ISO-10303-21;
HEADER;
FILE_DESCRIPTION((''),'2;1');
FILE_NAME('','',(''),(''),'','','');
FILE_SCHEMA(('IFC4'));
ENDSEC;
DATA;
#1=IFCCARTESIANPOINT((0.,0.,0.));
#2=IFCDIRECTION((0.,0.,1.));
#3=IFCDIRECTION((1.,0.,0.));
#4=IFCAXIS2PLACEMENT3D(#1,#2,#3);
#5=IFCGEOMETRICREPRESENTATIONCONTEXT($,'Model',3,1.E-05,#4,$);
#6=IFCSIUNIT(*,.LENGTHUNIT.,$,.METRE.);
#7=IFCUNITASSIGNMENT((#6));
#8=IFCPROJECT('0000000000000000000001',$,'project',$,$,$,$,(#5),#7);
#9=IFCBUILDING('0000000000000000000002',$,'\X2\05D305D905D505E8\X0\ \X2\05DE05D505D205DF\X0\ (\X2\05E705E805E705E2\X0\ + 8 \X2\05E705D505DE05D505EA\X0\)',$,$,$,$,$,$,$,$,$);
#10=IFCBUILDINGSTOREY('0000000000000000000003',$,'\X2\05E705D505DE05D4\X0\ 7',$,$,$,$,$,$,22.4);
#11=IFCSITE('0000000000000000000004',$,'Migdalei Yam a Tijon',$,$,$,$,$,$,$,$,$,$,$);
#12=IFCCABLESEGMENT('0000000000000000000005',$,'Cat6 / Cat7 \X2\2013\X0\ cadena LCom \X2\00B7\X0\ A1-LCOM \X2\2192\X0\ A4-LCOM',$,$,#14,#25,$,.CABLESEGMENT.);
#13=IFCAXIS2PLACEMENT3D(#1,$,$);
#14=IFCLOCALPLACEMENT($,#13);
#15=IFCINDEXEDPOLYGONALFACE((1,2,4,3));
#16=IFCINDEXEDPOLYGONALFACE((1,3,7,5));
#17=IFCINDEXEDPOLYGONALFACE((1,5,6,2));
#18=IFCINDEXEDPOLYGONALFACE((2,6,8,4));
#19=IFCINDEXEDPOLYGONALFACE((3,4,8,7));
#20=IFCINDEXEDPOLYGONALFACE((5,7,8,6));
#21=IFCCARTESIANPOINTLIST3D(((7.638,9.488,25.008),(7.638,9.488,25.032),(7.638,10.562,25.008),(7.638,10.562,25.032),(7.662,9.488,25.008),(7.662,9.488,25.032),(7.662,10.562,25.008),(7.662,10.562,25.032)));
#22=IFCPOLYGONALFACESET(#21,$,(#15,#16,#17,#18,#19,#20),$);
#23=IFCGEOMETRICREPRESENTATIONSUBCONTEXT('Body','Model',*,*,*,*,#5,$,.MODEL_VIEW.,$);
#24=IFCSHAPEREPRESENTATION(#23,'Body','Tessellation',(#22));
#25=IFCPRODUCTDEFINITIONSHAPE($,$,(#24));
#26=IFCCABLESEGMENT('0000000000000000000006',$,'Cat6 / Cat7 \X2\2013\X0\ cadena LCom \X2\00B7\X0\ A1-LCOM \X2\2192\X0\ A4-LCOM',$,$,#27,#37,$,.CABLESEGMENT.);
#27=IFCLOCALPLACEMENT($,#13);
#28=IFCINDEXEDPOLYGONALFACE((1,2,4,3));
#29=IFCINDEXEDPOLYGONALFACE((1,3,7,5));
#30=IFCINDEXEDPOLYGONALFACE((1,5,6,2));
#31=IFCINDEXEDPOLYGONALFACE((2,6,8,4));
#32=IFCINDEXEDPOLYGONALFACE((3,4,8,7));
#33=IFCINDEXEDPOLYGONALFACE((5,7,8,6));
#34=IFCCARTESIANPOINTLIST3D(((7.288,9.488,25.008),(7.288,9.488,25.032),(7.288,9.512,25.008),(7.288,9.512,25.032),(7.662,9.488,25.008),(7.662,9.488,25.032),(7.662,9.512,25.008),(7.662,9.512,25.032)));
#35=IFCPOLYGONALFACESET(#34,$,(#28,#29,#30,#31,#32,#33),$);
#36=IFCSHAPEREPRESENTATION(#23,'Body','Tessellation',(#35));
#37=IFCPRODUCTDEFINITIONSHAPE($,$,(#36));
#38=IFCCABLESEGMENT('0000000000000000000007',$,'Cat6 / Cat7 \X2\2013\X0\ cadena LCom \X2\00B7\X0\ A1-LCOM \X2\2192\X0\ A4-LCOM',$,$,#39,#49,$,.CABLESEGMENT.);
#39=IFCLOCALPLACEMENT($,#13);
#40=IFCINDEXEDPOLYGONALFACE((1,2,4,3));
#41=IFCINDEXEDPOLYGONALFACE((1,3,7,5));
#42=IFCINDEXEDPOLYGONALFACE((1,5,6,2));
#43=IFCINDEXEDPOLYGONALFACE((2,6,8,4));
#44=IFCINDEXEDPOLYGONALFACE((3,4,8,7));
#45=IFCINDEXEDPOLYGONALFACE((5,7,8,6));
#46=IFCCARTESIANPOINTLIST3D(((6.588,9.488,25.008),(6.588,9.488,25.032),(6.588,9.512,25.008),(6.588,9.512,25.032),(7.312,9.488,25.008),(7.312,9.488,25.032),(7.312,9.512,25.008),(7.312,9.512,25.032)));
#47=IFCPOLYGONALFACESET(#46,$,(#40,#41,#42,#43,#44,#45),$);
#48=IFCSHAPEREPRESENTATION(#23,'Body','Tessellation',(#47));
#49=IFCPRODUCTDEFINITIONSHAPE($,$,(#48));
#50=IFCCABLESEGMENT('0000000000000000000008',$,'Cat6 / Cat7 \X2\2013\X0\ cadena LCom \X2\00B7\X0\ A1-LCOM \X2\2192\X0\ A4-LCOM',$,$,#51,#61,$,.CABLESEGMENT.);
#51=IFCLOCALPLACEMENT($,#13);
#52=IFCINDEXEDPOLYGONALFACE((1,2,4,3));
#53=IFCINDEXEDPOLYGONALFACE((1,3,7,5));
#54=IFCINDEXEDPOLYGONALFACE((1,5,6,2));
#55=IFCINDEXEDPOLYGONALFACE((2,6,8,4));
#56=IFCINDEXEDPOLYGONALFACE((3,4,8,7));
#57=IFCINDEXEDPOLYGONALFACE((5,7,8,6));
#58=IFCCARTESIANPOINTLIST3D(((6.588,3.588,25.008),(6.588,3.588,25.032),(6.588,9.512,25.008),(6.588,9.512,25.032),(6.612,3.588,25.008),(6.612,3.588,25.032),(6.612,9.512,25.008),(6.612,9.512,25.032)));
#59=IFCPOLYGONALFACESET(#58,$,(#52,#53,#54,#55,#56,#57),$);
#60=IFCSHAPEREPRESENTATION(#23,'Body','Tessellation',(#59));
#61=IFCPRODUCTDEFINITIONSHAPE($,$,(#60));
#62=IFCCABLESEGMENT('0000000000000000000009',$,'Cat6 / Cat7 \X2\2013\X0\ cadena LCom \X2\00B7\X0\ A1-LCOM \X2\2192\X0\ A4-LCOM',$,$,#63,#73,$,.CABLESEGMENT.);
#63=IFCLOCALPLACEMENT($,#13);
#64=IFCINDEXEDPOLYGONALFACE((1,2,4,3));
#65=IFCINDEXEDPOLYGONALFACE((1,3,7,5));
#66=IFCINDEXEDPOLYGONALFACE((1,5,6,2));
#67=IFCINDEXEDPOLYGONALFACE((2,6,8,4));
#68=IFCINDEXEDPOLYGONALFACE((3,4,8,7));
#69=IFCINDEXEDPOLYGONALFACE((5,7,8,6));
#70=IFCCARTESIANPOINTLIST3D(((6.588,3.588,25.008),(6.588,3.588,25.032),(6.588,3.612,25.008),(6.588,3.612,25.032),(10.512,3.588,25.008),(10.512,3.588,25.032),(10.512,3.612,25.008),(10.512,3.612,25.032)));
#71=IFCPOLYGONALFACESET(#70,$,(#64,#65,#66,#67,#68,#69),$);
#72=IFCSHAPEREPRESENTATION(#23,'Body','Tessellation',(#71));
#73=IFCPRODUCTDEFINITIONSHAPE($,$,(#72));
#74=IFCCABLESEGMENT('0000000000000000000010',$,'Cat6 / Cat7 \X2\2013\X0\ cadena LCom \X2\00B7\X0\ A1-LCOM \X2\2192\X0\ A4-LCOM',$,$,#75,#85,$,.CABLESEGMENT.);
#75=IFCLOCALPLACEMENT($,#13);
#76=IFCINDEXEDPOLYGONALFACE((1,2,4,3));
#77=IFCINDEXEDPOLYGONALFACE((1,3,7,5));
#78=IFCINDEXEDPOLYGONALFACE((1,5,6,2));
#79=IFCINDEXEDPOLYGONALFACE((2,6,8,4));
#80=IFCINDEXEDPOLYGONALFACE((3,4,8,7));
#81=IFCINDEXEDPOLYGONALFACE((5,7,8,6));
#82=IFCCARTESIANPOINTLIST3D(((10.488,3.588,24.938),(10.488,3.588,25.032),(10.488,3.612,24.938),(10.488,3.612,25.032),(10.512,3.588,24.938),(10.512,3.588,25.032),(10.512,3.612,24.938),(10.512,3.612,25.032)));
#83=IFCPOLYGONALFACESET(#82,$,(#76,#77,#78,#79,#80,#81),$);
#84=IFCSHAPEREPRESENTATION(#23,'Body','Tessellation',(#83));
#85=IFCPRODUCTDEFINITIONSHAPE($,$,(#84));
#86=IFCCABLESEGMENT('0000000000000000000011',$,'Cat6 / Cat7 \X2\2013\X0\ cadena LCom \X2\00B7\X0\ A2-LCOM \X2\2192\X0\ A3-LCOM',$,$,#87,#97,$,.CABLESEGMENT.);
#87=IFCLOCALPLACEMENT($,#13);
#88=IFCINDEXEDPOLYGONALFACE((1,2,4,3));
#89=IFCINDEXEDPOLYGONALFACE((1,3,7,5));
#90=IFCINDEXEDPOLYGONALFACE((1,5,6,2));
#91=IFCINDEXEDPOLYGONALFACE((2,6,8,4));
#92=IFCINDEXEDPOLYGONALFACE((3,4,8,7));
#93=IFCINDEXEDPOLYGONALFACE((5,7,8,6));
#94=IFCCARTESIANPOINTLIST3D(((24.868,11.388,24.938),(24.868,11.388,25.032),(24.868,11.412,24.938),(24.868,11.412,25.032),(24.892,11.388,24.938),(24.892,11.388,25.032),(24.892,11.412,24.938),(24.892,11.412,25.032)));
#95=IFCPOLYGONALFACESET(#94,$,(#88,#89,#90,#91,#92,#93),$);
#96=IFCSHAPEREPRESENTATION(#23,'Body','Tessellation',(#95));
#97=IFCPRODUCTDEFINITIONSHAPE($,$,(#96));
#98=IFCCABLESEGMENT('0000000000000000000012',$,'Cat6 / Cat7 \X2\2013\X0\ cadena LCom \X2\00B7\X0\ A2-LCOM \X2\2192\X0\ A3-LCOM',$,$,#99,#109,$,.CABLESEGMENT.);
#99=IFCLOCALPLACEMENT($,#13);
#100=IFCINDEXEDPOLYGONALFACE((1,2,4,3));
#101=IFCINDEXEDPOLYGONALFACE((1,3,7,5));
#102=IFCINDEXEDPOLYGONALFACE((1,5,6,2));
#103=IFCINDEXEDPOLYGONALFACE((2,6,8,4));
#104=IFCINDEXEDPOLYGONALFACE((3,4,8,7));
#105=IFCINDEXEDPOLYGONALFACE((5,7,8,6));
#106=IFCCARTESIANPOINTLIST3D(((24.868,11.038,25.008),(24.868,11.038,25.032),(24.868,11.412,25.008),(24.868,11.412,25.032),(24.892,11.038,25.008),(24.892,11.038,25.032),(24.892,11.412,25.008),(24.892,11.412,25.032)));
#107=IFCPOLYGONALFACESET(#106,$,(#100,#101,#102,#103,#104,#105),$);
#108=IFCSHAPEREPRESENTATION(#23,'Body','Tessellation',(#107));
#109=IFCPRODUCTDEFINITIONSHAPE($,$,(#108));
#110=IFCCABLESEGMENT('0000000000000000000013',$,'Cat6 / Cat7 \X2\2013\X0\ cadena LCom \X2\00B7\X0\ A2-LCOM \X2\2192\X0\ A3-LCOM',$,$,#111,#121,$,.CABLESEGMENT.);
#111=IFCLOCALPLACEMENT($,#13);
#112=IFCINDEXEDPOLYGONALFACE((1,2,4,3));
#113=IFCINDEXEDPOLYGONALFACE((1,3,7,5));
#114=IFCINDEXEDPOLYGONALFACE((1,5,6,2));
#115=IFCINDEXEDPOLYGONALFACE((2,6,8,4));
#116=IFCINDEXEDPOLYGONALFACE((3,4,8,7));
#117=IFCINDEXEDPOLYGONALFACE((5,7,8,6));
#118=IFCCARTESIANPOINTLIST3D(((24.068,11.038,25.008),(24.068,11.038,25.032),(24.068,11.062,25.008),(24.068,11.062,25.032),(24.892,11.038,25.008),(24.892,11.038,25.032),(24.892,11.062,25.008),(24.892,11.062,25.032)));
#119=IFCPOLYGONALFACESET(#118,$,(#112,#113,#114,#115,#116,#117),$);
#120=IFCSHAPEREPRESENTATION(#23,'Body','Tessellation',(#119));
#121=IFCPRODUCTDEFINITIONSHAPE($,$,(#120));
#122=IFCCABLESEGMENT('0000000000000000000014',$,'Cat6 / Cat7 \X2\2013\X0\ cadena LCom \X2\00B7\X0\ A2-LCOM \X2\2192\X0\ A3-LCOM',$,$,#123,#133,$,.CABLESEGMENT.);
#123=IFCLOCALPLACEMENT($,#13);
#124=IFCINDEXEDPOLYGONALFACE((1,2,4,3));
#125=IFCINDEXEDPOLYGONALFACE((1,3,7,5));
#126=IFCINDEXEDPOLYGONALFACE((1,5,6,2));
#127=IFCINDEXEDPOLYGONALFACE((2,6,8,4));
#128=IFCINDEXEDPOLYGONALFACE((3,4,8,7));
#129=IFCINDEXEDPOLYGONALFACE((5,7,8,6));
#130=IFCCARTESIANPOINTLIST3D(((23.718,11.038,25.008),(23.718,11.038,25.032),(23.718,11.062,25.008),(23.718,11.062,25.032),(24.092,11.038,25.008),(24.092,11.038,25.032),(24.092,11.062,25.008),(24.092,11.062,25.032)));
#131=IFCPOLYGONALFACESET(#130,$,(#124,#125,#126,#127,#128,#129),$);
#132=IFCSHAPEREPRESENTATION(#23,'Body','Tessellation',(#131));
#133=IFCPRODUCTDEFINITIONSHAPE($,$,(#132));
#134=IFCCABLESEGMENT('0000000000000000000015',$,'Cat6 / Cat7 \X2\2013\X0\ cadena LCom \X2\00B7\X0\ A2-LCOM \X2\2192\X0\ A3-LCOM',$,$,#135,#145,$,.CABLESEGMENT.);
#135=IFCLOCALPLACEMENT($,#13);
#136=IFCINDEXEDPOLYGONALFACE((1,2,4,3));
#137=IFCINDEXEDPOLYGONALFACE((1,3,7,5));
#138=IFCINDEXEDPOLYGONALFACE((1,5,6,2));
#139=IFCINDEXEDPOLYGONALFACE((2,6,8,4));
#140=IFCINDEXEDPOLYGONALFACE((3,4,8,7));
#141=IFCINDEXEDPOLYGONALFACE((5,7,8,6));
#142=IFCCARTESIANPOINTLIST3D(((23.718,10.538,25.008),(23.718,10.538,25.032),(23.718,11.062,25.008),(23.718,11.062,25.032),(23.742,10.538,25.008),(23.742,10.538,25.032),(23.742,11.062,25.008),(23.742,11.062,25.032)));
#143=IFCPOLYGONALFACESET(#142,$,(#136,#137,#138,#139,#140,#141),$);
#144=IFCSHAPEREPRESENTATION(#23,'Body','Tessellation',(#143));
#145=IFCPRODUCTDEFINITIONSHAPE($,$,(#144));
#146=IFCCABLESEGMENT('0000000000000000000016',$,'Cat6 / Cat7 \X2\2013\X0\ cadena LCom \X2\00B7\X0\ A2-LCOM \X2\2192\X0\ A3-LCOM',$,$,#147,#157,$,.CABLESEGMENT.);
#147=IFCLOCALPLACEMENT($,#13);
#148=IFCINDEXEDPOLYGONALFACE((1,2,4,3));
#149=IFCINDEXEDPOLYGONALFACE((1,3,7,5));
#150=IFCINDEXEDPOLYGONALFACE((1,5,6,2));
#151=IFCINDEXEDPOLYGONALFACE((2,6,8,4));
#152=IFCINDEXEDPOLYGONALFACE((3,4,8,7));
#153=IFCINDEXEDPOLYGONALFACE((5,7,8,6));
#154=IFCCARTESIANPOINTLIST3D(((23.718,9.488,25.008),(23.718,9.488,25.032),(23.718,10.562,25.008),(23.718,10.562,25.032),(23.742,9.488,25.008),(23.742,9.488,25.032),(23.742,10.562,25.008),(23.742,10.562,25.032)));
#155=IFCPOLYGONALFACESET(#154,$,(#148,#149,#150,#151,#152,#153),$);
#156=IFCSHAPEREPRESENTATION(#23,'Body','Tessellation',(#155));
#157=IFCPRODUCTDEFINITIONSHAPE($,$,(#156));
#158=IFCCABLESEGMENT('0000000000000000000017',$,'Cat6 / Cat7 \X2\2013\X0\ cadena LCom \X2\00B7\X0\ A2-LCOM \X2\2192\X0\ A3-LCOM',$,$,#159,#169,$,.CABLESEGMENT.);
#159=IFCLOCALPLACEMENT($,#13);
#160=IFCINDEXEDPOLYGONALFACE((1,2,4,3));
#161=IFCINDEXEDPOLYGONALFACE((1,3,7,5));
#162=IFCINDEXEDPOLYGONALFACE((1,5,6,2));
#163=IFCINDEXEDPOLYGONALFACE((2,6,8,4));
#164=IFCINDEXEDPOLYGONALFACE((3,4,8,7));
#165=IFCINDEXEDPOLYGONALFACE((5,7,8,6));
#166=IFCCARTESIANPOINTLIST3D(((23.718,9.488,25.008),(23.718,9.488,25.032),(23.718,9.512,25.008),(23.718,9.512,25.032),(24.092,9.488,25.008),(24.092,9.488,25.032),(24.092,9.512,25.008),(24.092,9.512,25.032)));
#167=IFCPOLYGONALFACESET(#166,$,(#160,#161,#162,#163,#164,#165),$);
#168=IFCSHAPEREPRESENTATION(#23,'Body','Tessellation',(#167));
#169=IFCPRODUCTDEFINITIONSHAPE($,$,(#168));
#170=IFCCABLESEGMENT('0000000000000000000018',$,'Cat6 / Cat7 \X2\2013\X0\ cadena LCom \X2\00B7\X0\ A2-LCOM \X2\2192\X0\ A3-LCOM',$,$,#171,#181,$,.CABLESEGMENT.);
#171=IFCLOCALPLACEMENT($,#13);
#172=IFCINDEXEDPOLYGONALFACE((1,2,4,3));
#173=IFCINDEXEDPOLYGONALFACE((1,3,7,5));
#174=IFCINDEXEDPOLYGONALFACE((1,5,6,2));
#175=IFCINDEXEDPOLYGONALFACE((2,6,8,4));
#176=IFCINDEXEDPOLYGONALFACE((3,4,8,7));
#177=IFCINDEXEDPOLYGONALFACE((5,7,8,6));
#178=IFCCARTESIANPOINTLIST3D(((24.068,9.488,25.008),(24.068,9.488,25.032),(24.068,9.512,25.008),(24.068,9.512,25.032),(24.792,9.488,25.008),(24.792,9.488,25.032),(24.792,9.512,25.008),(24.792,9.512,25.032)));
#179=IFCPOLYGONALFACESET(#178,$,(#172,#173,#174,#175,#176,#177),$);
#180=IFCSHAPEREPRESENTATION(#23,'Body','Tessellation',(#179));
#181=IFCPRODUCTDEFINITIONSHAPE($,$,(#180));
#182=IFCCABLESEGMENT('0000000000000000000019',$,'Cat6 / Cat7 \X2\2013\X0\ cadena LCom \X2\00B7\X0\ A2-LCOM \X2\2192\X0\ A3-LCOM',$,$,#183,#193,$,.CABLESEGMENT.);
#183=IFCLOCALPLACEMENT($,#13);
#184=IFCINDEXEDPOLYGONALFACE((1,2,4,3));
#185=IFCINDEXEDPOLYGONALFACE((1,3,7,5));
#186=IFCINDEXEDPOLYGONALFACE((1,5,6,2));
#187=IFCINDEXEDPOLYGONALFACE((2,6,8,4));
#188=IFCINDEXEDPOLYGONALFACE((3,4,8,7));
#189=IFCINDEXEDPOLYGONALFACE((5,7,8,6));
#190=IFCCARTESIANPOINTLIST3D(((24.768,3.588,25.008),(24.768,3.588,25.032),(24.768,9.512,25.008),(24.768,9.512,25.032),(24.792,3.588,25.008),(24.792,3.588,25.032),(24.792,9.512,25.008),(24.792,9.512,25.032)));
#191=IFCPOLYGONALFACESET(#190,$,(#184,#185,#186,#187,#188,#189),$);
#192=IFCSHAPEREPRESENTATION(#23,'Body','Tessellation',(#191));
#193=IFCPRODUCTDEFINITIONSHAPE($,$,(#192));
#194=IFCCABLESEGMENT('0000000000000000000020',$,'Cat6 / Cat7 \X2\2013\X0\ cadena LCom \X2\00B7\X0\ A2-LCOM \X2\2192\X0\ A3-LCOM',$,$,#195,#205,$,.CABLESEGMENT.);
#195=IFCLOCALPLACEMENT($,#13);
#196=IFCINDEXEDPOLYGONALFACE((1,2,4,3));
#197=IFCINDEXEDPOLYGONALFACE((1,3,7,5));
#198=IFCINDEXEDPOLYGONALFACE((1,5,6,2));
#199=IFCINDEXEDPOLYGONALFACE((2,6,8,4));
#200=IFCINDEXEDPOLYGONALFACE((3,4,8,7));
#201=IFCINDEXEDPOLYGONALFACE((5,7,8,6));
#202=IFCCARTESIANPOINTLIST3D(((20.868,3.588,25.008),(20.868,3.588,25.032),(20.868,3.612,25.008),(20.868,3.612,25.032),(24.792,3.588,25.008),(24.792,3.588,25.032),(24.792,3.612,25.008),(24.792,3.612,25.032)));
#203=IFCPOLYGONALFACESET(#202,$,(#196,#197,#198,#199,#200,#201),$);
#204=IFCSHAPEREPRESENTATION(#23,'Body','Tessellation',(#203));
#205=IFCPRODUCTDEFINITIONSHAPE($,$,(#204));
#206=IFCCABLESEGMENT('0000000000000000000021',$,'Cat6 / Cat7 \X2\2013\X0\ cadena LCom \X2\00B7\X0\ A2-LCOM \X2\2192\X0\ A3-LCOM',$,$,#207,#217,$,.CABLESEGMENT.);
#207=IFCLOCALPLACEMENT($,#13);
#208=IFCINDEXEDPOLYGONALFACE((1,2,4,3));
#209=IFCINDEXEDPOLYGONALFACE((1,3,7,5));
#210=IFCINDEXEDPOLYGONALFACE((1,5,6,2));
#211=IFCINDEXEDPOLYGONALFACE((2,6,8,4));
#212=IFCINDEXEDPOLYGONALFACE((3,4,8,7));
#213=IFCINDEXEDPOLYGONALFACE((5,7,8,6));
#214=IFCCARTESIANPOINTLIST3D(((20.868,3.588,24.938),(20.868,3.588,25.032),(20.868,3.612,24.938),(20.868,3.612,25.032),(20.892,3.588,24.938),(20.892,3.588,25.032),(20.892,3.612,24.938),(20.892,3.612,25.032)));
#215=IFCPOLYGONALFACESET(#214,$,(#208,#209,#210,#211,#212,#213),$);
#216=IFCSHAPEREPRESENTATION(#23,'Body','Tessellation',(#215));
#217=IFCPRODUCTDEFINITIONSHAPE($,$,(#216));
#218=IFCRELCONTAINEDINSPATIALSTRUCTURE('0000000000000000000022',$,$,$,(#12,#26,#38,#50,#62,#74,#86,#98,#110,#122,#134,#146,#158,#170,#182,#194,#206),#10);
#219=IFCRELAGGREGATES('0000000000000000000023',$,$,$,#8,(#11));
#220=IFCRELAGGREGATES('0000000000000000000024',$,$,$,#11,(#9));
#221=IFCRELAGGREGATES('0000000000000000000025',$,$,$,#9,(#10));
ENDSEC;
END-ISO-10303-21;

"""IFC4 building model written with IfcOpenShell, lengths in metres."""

from ifc_helpers import new_model, si_unit, frame, origin_with_axes, context, subcontext, project, spatial, line, indexed_curve, outline, extrude, element, save


model = new_model("IFC4")

# Units and contexts
model_context = context("Model", 3, precision=1e-05, world=origin_with_axes())
body_context = subcontext(model_context, "Body", "Model", "MODEL_VIEW")
ifc_project = project(units=[si_unit("LENGTHUNIT", "METRE")], contexts=[model_context])

# Site, building, storey
site = spatial("IfcSite", under=ifc_project, Name="Migdalei Yam a Tijon")
building = spatial("IfcBuilding", under=site, Name="דיור מוגן (קרקע + 8 קומות)")
storey = spatial("IfcBuildingStorey", under=building, Name="קומה 7", Elevation=22.4)

# Cable segments
element("IfcCableSegment", 1, inside=storey, Name="Cat6 / Cat7 – cadena LCom · A1-LCOM → A4-LCOM", PredefinedType="CABLESEGMENT", context=body_context, shape_type="SweptSolid", body=[
    extrude(outline(indexed_curve([(0.0, 0.0), (0.024, 0.0), (0.024, 1.074), (0.0, 1.074)], segments=[line(1, 2, 3, 4, 1)])), frame((7.638, 9.488, 25.008), z_axis=(0.0, 0.0, 1.0), x_axis=(1.0, 0.0, 0.0)), (0.0, 0.0, 1.0), 0.024),
])
element("IfcCableSegment", 2, inside=storey, Name="Cat6 / Cat7 – cadena LCom · A1-LCOM → A4-LCOM", PredefinedType="CABLESEGMENT", context=body_context, shape_type="SweptSolid", body=[
    extrude(outline(indexed_curve([(0.0, 0.0), (0.374, 0.0), (0.374, 0.024), (0.0, 0.024)], segments=[line(1, 2, 3, 4, 1)])), frame((7.288, 9.488, 25.008), z_axis=(0.0, 0.0, 1.0), x_axis=(1.0, 0.0, 0.0)), (0.0, 0.0, 1.0), 0.024),
])
element("IfcCableSegment", 3, inside=storey, Name="Cat6 / Cat7 – cadena LCom · A1-LCOM → A4-LCOM", PredefinedType="CABLESEGMENT", context=body_context, shape_type="SweptSolid", body=[
    extrude(outline(indexed_curve([(0.0, 0.0), (0.724, 0.0), (0.724, 0.024), (0.0, 0.024)], segments=[line(1, 2, 3, 4, 1)])), frame((6.588, 9.488, 25.008), z_axis=(0.0, 0.0, 1.0), x_axis=(1.0, 0.0, 0.0)), (0.0, 0.0, 1.0), 0.024),
])
element("IfcCableSegment", 4, inside=storey, Name="Cat6 / Cat7 – cadena LCom · A1-LCOM → A4-LCOM", PredefinedType="CABLESEGMENT", context=body_context, shape_type="SweptSolid", body=[
    extrude(outline(indexed_curve([(0.0, 0.0), (0.024, 0.0), (0.024, 5.924), (0.0, 5.924)], segments=[line(1, 2, 3, 4, 1)])), frame((6.588, 3.588, 25.008), z_axis=(0.0, 0.0, 1.0), x_axis=(1.0, 0.0, 0.0)), (0.0, 0.0, 1.0), 0.024),
])
element("IfcCableSegment", 5, inside=storey, Name="Cat6 / Cat7 – cadena LCom · A1-LCOM → A4-LCOM", PredefinedType="CABLESEGMENT", context=body_context, shape_type="SweptSolid", body=[
    extrude(outline(indexed_curve([(0.0, 0.0), (3.924, 0.0), (3.924, 0.024), (0.0, 0.024)], segments=[line(1, 2, 3, 4, 1)])), frame((6.588, 3.588, 25.008), z_axis=(0.0, 0.0, 1.0), x_axis=(1.0, 0.0, 0.0)), (0.0, 0.0, 1.0), 0.024),
])
element("IfcCableSegment", 6, inside=storey, Name="Cat6 / Cat7 – cadena LCom · A1-LCOM → A4-LCOM", PredefinedType="CABLESEGMENT", context=body_context, shape_type="SweptSolid", body=[
    extrude(outline(indexed_curve([(0.0, 0.0), (0.024, 0.0), (0.024, 0.024), (0.0, 0.024)], segments=[line(1, 2, 3, 4, 1)])), frame((10.488, 3.588, 24.938), z_axis=(0.0, 0.0, 1.0), x_axis=(1.0, 0.0, 0.0)), (0.0, 0.0, 1.0), 0.094),
])
element("IfcCableSegment", 7, inside=storey, Name="Cat6 / Cat7 – cadena LCom · A2-LCOM → A3-LCOM", PredefinedType="CABLESEGMENT", context=body_context, shape_type="SweptSolid", body=[
    extrude(outline(indexed_curve([(0.0, 0.0), (0.024, 0.0), (0.024, 0.024), (0.0, 0.024)], segments=[line(1, 2, 3, 4, 1)])), frame((24.868, 11.388, 24.938), z_axis=(0.0, 0.0, 1.0), x_axis=(1.0, 0.0, 0.0)), (0.0, 0.0, 1.0), 0.094),
])
element("IfcCableSegment", 8, inside=storey, Name="Cat6 / Cat7 – cadena LCom · A2-LCOM → A3-LCOM", PredefinedType="CABLESEGMENT", context=body_context, shape_type="SweptSolid", body=[
    extrude(outline(indexed_curve([(0.0, 0.0), (0.024, 0.0), (0.024, 0.374), (0.0, 0.374)], segments=[line(1, 2, 3, 4, 1)])), frame((24.868, 11.038, 25.008), z_axis=(0.0, 0.0, 1.0), x_axis=(1.0, 0.0, 0.0)), (0.0, 0.0, 1.0), 0.024),
])
element("IfcCableSegment", 9, inside=storey, Name="Cat6 / Cat7 – cadena LCom · A2-LCOM → A3-LCOM", PredefinedType="CABLESEGMENT", context=body_context, shape_type="SweptSolid", body=[
    extrude(outline(indexed_curve([(0.0, 0.0), (0.824, 0.0), (0.824, 0.024), (0.0, 0.024)], segments=[line(1, 2, 3, 4, 1)])), frame((24.068, 11.038, 25.008), z_axis=(0.0, 0.0, 1.0), x_axis=(1.0, 0.0, 0.0)), (0.0, 0.0, 1.0), 0.024),
])
element("IfcCableSegment", 10, inside=storey, Name="Cat6 / Cat7 – cadena LCom · A2-LCOM → A3-LCOM", PredefinedType="CABLESEGMENT", context=body_context, shape_type="SweptSolid", body=[
    extrude(outline(indexed_curve([(0.0, 0.0), (0.374, 0.0), (0.374, 0.024), (0.0, 0.024)], segments=[line(1, 2, 3, 4, 1)])), frame((23.718, 11.038, 25.008), z_axis=(0.0, 0.0, 1.0), x_axis=(1.0, 0.0, 0.0)), (0.0, 0.0, 1.0), 0.024),
])
element("IfcCableSegment", 11, inside=storey, Name="Cat6 / Cat7 – cadena LCom · A2-LCOM → A3-LCOM", PredefinedType="CABLESEGMENT", context=body_context, shape_type="SweptSolid", body=[
    extrude(outline(indexed_curve([(0.0, 0.0), (0.024, 0.0), (0.024, 0.524), (0.0, 0.524)], segments=[line(1, 2, 3, 4, 1)])), frame((23.718, 10.538, 25.008), z_axis=(0.0, 0.0, 1.0), x_axis=(1.0, 0.0, 0.0)), (0.0, 0.0, 1.0), 0.024),
])
element("IfcCableSegment", 12, inside=storey, Name="Cat6 / Cat7 – cadena LCom · A2-LCOM → A3-LCOM", PredefinedType="CABLESEGMENT", context=body_context, shape_type="SweptSolid", body=[
    extrude(outline(indexed_curve([(0.0, 0.0), (0.024, 0.0), (0.024, 1.074), (0.0, 1.074)], segments=[line(1, 2, 3, 4, 1)])), frame((23.718, 9.488, 25.008), z_axis=(0.0, 0.0, 1.0), x_axis=(1.0, 0.0, 0.0)), (0.0, 0.0, 1.0), 0.024),
])
element("IfcCableSegment", 13, inside=storey, Name="Cat6 / Cat7 – cadena LCom · A2-LCOM → A3-LCOM", PredefinedType="CABLESEGMENT", context=body_context, shape_type="SweptSolid", body=[
    extrude(outline(indexed_curve([(0.0, 0.0), (0.374, 0.0), (0.374, 0.024), (0.0, 0.024)], segments=[line(1, 2, 3, 4, 1)])), frame((23.718, 9.488, 25.008), z_axis=(0.0, 0.0, 1.0), x_axis=(1.0, 0.0, 0.0)), (0.0, 0.0, 1.0), 0.024),
])
element("IfcCableSegment", 14, inside=storey, Name="Cat6 / Cat7 – cadena LCom · A2-LCOM → A3-LCOM", PredefinedType="CABLESEGMENT", context=body_context, shape_type="SweptSolid", body=[
    extrude(outline(indexed_curve([(0.0, 0.0), (0.724, 0.0), (0.724, 0.024), (0.0, 0.024)], segments=[line(1, 2, 3, 4, 1)])), frame((24.068, 9.488, 25.008), z_axis=(0.0, 0.0, 1.0), x_axis=(1.0, 0.0, 0.0)), (0.0, 0.0, 1.0), 0.024),
])
element("IfcCableSegment", 15, inside=storey, Name="Cat6 / Cat7 – cadena LCom · A2-LCOM → A3-LCOM", PredefinedType="CABLESEGMENT", context=body_context, shape_type="SweptSolid", body=[
    extrude(outline(indexed_curve([(0.0, 0.0), (0.024, 0.0), (0.024, 5.924), (0.0, 5.924)], segments=[line(1, 2, 3, 4, 1)])), frame((24.768, 3.588, 25.008), z_axis=(0.0, 0.0, 1.0), x_axis=(1.0, 0.0, 0.0)), (0.0, 0.0, 1.0), 0.024),
])
element("IfcCableSegment", 16, inside=storey, Name="Cat6 / Cat7 – cadena LCom · A2-LCOM → A3-LCOM", PredefinedType="CABLESEGMENT", context=body_context, shape_type="SweptSolid", body=[
    extrude(outline(indexed_curve([(0.0, 0.0), (3.924, 0.0), (3.924, 0.024), (0.0, 0.024)], segments=[line(1, 2, 3, 4, 1)])), frame((20.868, 3.588, 25.008), z_axis=(0.0, 0.0, 1.0), x_axis=(1.0, 0.0, 0.0)), (0.0, 0.0, 1.0), 0.024),
])
element("IfcCableSegment", 17, inside=storey, Name="Cat6 / Cat7 – cadena LCom · A2-LCOM → A3-LCOM", PredefinedType="CABLESEGMENT", context=body_context, shape_type="SweptSolid", body=[
    extrude(outline(indexed_curve([(0.0, 0.0), (0.024, 0.0), (0.024, 0.024), (0.0, 0.024)], segments=[line(1, 2, 3, 4, 1)])), frame((20.868, 3.588, 24.938), z_axis=(0.0, 0.0, 1.0), x_axis=(1.0, 0.0, 0.0)), (0.0, 0.0, 1.0), 0.094),
])

save(model, "model.ifc")
